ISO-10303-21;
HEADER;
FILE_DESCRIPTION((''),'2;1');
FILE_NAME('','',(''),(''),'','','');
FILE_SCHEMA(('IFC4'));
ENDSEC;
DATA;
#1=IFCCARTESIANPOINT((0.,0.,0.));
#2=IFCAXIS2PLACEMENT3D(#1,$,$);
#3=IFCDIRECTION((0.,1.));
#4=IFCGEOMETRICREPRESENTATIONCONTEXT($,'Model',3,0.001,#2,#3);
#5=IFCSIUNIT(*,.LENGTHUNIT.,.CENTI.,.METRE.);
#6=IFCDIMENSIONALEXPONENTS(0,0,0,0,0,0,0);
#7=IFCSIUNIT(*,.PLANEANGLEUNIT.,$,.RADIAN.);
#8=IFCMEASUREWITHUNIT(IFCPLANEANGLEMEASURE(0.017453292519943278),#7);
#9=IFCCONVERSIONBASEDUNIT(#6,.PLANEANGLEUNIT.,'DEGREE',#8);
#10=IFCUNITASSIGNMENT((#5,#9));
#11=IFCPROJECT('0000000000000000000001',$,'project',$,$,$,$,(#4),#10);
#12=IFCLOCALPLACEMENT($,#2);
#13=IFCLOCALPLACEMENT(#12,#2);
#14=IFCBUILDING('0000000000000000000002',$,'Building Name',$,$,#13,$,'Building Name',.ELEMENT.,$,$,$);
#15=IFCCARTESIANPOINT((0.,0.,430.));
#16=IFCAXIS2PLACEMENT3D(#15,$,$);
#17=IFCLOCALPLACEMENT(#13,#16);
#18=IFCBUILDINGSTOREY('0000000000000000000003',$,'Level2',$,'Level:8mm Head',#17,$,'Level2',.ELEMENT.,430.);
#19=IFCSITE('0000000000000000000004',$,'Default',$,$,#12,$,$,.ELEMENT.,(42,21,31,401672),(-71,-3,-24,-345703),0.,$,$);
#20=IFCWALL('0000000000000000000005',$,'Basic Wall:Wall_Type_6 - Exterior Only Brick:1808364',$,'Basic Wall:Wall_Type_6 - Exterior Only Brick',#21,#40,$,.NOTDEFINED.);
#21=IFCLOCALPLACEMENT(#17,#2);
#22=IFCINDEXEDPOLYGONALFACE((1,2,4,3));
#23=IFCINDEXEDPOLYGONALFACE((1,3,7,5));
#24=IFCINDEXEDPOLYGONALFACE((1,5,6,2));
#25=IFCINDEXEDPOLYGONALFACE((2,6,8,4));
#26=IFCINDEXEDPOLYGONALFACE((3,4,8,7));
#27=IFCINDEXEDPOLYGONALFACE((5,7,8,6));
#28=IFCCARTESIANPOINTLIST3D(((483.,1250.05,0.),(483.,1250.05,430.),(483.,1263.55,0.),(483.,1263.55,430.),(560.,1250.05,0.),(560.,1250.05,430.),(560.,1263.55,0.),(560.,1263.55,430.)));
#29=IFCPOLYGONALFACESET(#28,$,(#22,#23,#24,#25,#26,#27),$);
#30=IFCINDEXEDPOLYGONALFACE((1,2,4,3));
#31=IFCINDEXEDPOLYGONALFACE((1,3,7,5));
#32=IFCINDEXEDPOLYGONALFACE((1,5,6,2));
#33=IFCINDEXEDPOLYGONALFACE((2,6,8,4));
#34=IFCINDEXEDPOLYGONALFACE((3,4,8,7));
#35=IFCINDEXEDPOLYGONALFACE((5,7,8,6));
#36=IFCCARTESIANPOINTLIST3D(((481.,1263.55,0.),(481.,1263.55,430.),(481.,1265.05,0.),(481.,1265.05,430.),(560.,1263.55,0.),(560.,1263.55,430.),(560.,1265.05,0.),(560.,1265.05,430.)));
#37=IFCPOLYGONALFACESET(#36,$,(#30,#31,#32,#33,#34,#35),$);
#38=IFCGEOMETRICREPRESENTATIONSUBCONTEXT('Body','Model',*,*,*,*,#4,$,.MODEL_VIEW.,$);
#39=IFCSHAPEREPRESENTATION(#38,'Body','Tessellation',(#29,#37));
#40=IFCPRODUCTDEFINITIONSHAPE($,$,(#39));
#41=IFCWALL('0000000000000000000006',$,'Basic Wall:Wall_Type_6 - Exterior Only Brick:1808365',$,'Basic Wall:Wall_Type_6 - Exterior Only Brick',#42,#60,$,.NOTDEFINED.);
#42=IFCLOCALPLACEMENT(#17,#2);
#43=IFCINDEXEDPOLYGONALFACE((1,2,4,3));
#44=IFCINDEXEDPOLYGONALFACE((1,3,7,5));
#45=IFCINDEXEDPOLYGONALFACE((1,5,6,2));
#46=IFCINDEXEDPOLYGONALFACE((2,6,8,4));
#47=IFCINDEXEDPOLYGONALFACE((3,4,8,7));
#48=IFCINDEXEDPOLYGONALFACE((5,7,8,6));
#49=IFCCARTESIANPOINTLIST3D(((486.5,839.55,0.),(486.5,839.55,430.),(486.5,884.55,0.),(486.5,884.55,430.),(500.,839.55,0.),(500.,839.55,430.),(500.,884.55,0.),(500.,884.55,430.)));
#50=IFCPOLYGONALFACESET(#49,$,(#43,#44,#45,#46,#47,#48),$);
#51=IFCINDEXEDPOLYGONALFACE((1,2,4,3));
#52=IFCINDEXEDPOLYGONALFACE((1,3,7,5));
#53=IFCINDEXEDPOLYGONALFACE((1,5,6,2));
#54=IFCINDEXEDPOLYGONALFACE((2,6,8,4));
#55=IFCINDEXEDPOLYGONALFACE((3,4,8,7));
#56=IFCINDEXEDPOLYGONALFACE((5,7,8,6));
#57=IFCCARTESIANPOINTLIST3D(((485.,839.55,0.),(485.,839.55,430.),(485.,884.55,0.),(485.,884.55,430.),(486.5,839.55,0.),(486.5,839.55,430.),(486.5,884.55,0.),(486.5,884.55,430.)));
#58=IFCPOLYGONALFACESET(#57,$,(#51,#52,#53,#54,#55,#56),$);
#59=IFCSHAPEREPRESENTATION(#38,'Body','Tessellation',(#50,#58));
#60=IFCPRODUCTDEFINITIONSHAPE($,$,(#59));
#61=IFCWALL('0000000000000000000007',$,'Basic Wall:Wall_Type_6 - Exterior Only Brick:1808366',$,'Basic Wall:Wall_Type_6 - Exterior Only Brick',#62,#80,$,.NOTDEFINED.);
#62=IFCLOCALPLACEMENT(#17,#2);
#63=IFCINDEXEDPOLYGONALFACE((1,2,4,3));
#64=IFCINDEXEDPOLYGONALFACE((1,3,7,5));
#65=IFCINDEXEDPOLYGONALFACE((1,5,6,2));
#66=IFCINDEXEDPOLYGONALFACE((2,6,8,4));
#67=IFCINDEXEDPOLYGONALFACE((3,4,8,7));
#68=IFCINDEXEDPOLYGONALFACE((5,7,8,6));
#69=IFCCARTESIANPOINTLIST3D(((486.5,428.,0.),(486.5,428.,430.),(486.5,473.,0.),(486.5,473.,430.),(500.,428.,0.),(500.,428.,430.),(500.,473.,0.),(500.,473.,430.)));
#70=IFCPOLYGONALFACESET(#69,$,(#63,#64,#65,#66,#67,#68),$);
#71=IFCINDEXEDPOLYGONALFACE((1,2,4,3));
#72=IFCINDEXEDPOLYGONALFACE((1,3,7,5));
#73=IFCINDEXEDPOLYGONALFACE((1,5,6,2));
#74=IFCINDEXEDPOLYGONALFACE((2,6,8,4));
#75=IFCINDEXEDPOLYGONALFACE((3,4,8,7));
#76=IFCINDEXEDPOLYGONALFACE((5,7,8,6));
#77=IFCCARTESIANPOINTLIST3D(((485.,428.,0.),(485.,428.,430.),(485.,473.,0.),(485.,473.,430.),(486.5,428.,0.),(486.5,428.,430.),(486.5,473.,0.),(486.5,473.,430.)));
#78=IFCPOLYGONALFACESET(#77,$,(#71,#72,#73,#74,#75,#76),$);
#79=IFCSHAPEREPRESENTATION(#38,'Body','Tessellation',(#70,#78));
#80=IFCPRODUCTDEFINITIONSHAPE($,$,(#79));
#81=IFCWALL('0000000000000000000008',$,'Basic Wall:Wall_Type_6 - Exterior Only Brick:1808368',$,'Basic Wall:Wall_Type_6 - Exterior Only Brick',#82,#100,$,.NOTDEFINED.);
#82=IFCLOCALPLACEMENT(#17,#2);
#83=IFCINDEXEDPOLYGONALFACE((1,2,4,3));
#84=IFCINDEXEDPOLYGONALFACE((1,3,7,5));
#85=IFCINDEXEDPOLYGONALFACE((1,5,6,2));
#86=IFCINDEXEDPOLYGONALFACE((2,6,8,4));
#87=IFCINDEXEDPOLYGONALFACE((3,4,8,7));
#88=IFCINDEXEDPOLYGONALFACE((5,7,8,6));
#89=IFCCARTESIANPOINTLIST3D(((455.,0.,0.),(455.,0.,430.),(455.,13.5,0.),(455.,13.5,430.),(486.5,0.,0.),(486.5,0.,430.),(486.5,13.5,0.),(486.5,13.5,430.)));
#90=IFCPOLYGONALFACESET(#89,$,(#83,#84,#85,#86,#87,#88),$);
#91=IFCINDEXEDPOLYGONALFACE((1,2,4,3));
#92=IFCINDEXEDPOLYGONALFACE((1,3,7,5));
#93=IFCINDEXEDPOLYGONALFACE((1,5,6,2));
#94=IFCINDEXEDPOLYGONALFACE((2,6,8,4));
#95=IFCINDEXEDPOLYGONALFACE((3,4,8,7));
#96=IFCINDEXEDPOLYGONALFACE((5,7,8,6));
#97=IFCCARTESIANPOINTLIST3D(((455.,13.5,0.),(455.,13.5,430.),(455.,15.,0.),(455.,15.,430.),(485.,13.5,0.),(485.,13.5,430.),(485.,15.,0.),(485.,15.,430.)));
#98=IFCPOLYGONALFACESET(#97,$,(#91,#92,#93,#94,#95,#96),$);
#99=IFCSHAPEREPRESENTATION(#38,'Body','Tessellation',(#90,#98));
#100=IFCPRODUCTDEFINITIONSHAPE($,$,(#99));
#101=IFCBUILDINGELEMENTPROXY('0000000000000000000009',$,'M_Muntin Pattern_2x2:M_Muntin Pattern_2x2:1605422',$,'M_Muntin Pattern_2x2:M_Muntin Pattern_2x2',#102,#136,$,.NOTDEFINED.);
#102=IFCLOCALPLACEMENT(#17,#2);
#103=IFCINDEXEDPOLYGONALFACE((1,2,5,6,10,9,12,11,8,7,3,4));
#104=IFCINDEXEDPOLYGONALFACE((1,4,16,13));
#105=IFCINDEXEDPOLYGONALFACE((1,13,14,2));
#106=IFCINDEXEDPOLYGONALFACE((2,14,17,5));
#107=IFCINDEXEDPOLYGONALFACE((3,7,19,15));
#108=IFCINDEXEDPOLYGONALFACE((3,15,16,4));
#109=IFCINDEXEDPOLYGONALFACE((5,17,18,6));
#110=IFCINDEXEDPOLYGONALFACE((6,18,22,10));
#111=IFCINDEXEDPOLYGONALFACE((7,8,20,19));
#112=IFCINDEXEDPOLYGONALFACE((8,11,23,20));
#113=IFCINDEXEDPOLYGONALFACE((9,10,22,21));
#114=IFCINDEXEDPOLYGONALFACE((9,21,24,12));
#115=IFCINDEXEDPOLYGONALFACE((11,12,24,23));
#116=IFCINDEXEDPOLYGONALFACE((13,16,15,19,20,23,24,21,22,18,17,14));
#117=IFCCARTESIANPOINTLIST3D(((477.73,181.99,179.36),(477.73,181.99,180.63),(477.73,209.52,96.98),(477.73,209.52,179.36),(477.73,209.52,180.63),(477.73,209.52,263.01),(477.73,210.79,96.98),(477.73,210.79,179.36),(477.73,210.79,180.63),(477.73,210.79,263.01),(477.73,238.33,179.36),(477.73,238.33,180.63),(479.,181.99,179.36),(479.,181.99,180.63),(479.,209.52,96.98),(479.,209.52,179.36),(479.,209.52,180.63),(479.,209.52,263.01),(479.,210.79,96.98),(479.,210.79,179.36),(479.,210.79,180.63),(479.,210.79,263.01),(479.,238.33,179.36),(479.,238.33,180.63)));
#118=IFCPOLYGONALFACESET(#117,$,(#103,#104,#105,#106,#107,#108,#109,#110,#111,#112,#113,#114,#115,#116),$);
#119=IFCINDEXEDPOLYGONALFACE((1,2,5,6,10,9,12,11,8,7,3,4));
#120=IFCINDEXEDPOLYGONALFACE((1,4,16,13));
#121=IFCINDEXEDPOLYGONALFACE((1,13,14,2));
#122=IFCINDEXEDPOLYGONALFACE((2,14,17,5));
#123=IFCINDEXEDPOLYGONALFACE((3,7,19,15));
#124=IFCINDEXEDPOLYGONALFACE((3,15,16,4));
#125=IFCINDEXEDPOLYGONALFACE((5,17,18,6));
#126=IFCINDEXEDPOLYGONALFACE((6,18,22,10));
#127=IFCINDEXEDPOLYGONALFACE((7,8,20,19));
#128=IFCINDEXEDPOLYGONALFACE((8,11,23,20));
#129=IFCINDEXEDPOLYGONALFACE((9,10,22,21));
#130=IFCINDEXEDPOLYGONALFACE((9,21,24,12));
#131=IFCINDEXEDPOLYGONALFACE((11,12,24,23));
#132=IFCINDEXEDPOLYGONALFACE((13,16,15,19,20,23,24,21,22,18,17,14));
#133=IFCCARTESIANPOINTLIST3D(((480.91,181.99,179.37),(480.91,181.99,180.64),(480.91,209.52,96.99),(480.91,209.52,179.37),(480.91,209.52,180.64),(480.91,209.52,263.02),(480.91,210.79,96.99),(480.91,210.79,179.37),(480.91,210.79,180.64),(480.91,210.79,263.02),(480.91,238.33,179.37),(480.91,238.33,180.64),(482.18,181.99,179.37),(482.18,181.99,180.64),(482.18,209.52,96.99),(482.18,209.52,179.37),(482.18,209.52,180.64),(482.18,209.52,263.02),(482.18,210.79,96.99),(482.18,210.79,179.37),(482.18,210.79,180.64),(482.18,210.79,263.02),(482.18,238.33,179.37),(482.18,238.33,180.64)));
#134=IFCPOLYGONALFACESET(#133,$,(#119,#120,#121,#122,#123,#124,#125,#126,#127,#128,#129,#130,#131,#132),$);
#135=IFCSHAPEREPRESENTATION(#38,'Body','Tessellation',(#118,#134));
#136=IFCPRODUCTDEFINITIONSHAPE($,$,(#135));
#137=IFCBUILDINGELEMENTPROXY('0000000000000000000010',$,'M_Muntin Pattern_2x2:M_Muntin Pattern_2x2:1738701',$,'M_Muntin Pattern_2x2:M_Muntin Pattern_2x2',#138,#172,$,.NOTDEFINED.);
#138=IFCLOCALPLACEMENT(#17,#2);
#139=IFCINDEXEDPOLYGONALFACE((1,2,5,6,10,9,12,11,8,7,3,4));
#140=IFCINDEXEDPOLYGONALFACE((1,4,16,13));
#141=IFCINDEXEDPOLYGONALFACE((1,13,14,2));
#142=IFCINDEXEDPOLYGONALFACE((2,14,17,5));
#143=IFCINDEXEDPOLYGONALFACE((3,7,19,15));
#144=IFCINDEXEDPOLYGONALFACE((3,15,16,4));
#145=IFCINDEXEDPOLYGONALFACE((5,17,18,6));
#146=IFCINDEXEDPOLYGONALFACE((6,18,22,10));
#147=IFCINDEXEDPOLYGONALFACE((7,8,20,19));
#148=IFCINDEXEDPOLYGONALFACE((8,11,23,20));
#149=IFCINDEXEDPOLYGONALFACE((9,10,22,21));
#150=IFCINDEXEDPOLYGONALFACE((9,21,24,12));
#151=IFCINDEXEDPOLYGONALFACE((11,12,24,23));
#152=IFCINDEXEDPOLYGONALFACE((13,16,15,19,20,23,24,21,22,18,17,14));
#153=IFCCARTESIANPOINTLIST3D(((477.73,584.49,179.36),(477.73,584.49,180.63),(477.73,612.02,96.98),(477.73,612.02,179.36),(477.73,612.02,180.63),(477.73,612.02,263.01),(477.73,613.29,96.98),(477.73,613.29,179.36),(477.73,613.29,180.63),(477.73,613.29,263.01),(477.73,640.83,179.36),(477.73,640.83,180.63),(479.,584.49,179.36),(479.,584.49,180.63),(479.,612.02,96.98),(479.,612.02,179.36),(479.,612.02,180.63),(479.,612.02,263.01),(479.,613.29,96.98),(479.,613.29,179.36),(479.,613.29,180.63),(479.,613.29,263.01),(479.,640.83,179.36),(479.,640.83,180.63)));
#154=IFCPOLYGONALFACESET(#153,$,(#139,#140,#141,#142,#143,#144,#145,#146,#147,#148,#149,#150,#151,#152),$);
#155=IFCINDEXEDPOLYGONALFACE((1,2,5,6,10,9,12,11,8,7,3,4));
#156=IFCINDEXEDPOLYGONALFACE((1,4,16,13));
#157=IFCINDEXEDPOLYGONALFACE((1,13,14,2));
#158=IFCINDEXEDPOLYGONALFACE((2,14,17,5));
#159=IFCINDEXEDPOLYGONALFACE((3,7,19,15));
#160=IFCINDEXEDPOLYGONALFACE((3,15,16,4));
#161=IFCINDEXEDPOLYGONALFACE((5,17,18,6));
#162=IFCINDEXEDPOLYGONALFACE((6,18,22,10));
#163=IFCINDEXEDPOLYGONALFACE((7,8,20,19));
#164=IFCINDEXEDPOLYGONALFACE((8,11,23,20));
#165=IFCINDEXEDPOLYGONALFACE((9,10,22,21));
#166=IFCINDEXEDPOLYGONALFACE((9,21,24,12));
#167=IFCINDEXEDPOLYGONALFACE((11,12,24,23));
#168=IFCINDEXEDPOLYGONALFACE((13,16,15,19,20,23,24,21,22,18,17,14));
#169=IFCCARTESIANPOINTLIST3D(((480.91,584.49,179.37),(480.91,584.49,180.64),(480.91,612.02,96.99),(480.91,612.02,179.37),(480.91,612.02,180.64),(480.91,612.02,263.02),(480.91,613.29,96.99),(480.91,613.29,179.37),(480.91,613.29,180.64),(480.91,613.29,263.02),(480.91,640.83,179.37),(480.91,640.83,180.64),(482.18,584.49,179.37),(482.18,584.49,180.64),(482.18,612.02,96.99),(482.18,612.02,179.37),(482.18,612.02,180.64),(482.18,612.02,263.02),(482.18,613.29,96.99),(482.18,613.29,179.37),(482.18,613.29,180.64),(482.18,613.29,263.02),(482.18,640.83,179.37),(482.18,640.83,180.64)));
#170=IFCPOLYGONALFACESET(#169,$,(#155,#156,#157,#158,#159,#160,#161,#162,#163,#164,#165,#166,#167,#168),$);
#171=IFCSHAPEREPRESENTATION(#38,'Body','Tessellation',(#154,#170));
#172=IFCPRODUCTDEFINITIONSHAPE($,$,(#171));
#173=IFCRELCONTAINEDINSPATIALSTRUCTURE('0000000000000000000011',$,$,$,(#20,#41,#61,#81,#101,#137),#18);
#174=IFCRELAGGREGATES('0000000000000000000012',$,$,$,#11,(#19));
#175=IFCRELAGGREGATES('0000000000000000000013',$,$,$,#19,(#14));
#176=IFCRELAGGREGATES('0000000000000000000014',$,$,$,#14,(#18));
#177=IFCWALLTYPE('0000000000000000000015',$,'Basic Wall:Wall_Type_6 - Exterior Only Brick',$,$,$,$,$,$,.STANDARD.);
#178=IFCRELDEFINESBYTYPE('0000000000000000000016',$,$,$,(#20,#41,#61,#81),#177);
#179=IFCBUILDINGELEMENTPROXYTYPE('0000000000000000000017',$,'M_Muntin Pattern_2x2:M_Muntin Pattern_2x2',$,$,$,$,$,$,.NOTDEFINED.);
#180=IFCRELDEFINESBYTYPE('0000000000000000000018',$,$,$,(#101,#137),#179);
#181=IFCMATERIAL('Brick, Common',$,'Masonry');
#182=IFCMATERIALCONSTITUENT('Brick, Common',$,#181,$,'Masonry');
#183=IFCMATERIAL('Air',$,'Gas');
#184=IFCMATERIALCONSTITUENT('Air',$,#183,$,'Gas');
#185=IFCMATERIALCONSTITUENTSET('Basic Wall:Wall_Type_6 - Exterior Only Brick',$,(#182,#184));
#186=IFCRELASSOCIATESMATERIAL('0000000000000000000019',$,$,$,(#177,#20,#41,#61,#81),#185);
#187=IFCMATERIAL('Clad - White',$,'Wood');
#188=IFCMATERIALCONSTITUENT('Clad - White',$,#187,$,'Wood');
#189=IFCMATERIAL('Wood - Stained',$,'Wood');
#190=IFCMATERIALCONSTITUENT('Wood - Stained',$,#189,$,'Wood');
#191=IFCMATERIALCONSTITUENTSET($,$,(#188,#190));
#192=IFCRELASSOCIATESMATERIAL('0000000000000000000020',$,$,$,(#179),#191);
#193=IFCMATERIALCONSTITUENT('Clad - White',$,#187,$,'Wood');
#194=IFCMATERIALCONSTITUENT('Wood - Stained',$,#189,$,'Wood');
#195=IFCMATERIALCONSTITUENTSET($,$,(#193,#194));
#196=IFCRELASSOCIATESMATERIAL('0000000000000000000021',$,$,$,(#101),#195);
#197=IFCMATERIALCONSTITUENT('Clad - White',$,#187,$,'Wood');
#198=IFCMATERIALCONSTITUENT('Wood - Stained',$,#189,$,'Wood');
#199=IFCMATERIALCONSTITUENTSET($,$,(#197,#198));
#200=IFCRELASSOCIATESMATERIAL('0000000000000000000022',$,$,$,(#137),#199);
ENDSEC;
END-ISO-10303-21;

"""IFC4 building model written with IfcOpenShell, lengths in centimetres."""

from ifc_helpers import new_model, entity, si_unit, converted_unit, direction, frame, origin, place, context, subcontext, project, spatial, indexed_curve, outline, extrude, source, transform, mapped, material, constituent, constituent_set, type_object, type_shapes, element, save


model = new_model("IFC4")

# Units and contexts
model_context = context("Model", 3, precision=0.001, world=origin(), true_north=direction((0.0, 1.0)))
body_context = subcontext(model_context, "Body", "Model", "MODEL_VIEW")
ifc_project = project(units=[si_unit("LENGTHUNIT", "METRE", prefix="CENTI"), converted_unit("PLANEANGLEUNIT", "DEGREE", entity("IfcPlaneAngleMeasure", 0.017453292519943278), si_unit("PLANEANGLEUNIT", "RADIAN"), dimensions=[0, 0, 0, 0, 0, 0, 0])], contexts=[model_context])

# Site, building, storey
site_placement = place(None, origin())
site = spatial("IfcSite", under=ifc_project, at=site_placement, Name="Default", CompositionType="ELEMENT", RefLatitude=(42, 21, 31, 401672), RefLongitude=(-71, -3, -24, -345703), RefElevation=0.0)
building_placement = place(site_placement, origin())
building = spatial("IfcBuilding", under=site, at=building_placement, Name="Building Name", LongName="Building Name", CompositionType="ELEMENT")
storey_placement = place(building_placement, frame((0.0, 0.0, 430.0)))
storey = spatial("IfcBuildingStorey", under=building, at=storey_placement, Name="Level2", ObjectType="Level:8mm Head", LongName="Level2", CompositionType="ELEMENT", Elevation=430.0)

# Shared definitions
ifc_material_1 = material(Name="Brick, Common", Category="Masonry")
ifc_material_2 = material(Name="Air", Category="Gas")

# Walls
ifc_constituent_1 = constituent(ifc_material_1, Name="Brick, Common", Category="Masonry")
ifc_constituent_2 = constituent(ifc_material_2, Name="Air", Category="Gas")
ifc_constituent_set_1 = constituent_set(constituents=[ifc_constituent_1, ifc_constituent_2], Name="Basic Wall:Wall_Type_6 - Exterior Only Brick")
wall_type_1 = type_object("IfcWallType", Name="Basic Wall:Wall_Type_6 - Exterior Only Brick", PredefinedType="STANDARD", material=ifc_constituent_set_1)
wall_1_placement = place(storey_placement, frame((560.0, 1257.55, 0.0), z_axis=(0.0, 0.0, 1.0), x_axis=(-1.0, 0.0, 0.0)))
element("IfcWall", 1, at=wall_1_placement, inside=storey, type_object=wall_type_1, material=ifc_constituent_set_1, Name="Basic Wall:Wall_Type_6 - Exterior Only Brick:1808364", ObjectType="Basic Wall:Wall_Type_6 - Exterior Only Brick", PredefinedType="NOTDEFINED", context=body_context, shape_type="SweptSolid", body=[
    extrude(outline(indexed_curve([(-6.75, -38.5), (6.75, -38.5), (6.75, 38.5), (-6.75, 38.5), (-6.75, -38.5)], self_intersect=False)), frame((38.5, 0.75, 0.0), z_axis=(0.0, 0.0, 1.0), x_axis=(0.0, -1.0, 0.0)), (0.0, 0.0, 1.0), 430.0),
    extrude(outline(indexed_curve([(-0.75, -39.5), (0.75, -39.5), (0.75, 39.5), (-0.75, 39.5), (-0.75, -39.5)], self_intersect=False)), frame((39.5, -6.75, 0.0), z_axis=(0.0, 0.0, 1.0), x_axis=(0.0, -1.0, 0.0)), (0.0, 0.0, 1.0), 430.0),
])
wall_2_placement = place(storey_placement, frame((492.5, 884.55, 0.0), z_axis=(0.0, 0.0, 1.0), x_axis=(0.0, -1.0, 0.0)))
element("IfcWall", 2, at=wall_2_placement, inside=storey, type_object=wall_type_1, material=ifc_constituent_set_1, Name="Basic Wall:Wall_Type_6 - Exterior Only Brick:1808365", ObjectType="Basic Wall:Wall_Type_6 - Exterior Only Brick", PredefinedType="NOTDEFINED", context=body_context, shape_type="SweptSolid", body=[
    extrude(outline(indexed_curve([(-6.75, -22.5), (6.75, -22.5), (6.75, 22.5), (-6.75, 22.5), (-6.75, -22.5)], self_intersect=False)), frame((22.5, 0.75, 0.0), z_axis=(0.0, 0.0, 1.0), x_axis=(0.0, -1.0, 0.0)), (0.0, 0.0, 1.0), 430.0),
    extrude(outline(indexed_curve([(-0.75, -22.5), (0.75, -22.5), (0.75, 22.5), (-0.75, 22.5), (-0.75, -22.5)], self_intersect=False)), frame((22.5, -6.75, 0.0), z_axis=(0.0, 0.0, 1.0), x_axis=(0.0, 1.0, 0.0)), (0.0, 0.0, 1.0), 430.0),
])
wall_3_placement = place(storey_placement, frame((492.5, 473.0, 0.0), z_axis=(0.0, 0.0, 1.0), x_axis=(0.0, -1.0, 0.0)))
element("IfcWall", 3, at=wall_3_placement, inside=storey, type_object=wall_type_1, material=ifc_constituent_set_1, Name="Basic Wall:Wall_Type_6 - Exterior Only Brick:1808366", ObjectType="Basic Wall:Wall_Type_6 - Exterior Only Brick", PredefinedType="NOTDEFINED", context=body_context, shape_type="SweptSolid", body=[
    extrude(outline(indexed_curve([(-6.75, -22.5), (6.75, -22.5), (6.75, 22.5), (-6.75, 22.5), (-6.75, -22.5)], self_intersect=False)), frame((22.5, 0.75, 0.0), z_axis=(0.0, 0.0, 1.0), x_axis=(0.0, -1.0, 0.0)), (0.0, 0.0, 1.0), 430.0),
    extrude(outline(indexed_curve([(-0.75, -22.5), (0.75, -22.5), (0.75, 22.5), (-0.75, 22.5), (-0.75, -22.5)], self_intersect=False)), frame((22.5, -6.75, 0.0), z_axis=(0.0, 0.0, 1.0), x_axis=(0.0, 1.0, 0.0)), (0.0, 0.0, 1.0), 430.0),
])
wall_4_placement = place(storey_placement, frame((485.0, 7.5, 0.0), z_axis=(0.0, 0.0, 1.0), x_axis=(-1.0, 0.0, 0.0)))
element("IfcWall", 4, at=wall_4_placement, inside=storey, type_object=wall_type_1, material=ifc_constituent_set_1, Name="Basic Wall:Wall_Type_6 - Exterior Only Brick:1808368", ObjectType="Basic Wall:Wall_Type_6 - Exterior Only Brick", PredefinedType="NOTDEFINED", context=body_context, shape_type="SweptSolid", body=[
    extrude(outline(indexed_curve([(-6.75, -15.75), (6.75, -15.75), (6.75, 15.75), (-6.75, 15.75), (-6.75, -15.75)], self_intersect=False)), frame((14.25, 0.75, 0.0), z_axis=(0.0, 0.0, 1.0), x_axis=(0.0, -1.0, 0.0)), (0.0, 0.0, 1.0), 430.0),
    extrude(outline(indexed_curve([(-0.75, -15.0), (0.75, -15.0), (0.75, 15.0), (-0.75, 15.0), (-0.75, -15.0)], self_intersect=False)), frame((15.0, -6.75, 0.0), z_axis=(0.0, 0.0, 1.0), x_axis=(0.0, 1.0, 0.0)), (0.0, 0.0, 1.0), 430.0),
])

# Building element proxies
ifc_material_3 = material(Name="Clad - White", Category="Wood")
ifc_constituent_3 = constituent(ifc_material_3, Name="Clad - White", Category="Wood")
ifc_material_4 = material(Name="Wood - Stained", Category="Wood")
ifc_constituent_4 = constituent(ifc_material_4, Name="Wood - Stained", Category="Wood")
ifc_constituent_set_2 = constituent_set(constituents=[ifc_constituent_3, ifc_constituent_4])
ifc_constituent_5 = constituent(ifc_material_3, Name="Clad - White", Category="Wood")
ifc_constituent_6 = constituent(ifc_material_4, Name="Wood - Stained", Category="Wood")
ifc_constituent_set_3 = constituent_set(constituents=[ifc_constituent_5, ifc_constituent_6])
building_element_proxy_type_1 = type_object("IfcBuildingElementProxyType", Name="M_Muntin Pattern_2x2:M_Muntin Pattern_2x2", PredefinedType="NOTDEFINED", material=ifc_constituent_set_3)
shared_shape_1 = source(origin(), body_context, "Body", "SweptSolid", [
    extrude(outline(indexed_curve([(0.64, -0.64), (83.01, -0.64), (83.01, 0.63), (0.64, 0.63), (0.64, 28.17), (-0.63, 28.17), (-0.63, 0.63), (-83.02, 0.63), (-83.02, -0.64), (-0.63, -0.64), (-0.63, -28.17), (0.64, -28.17), (0.64, -0.64)], self_intersect=False)), frame((0.0, 0.95, 83.01), z_axis=(0.0, 1.0, 0.0), x_axis=(0.0, 0.0, 1.0)), (0.0, 0.0, 1.0), 1.27),
    extrude(outline(indexed_curve([(0.64, -0.64), (83.02, -0.64), (83.02, 0.63), (0.64, 0.63), (0.64, 28.17), (-0.63, 28.17), (-0.63, 0.63), (-83.02, 0.63), (-83.02, -0.64), (-0.63, -0.64), (-0.63, -28.17), (0.64, -28.17), (0.64, -0.64)], self_intersect=False)), frame((0.0, -2.22, 83.02), z_axis=(0.0, 1.0, 0.0), x_axis=(0.0, 0.0, 1.0)), (0.0, 0.0, 1.0), 1.27),
])
type_shapes(building_element_proxy_type_1, [shared_shape_1])
proxy_1_placement = place(storey_placement, frame((479.95, 210.16, 96.99), z_axis=(0.0, 0.0, 1.0), x_axis=(0.0, 1.0, 0.0)))
element("IfcBuildingElementProxy", 5, at=proxy_1_placement, inside=storey, type_object=building_element_proxy_type_1, material=ifc_constituent_set_2, Name="M_Muntin Pattern_2x2:M_Muntin Pattern_2x2:1605422", ObjectType="M_Muntin Pattern_2x2:M_Muntin Pattern_2x2", PredefinedType="NOTDEFINED", context=body_context, shape_type="MappedRepresentation", body=[
    mapped(shared_shape_1, transform((0.0, 0.0, 0.0), scale=1.0)),
])
ifc_constituent_7 = constituent(ifc_material_3, Name="Clad - White", Category="Wood")
ifc_constituent_8 = constituent(ifc_material_4, Name="Wood - Stained", Category="Wood")
ifc_constituent_set_4 = constituent_set(constituents=[ifc_constituent_7, ifc_constituent_8])
proxy_2_placement = place(storey_placement, frame((479.95, 612.66, 96.99), z_axis=(0.0, 0.0, 1.0), x_axis=(0.0, 1.0, 0.0)))
element("IfcBuildingElementProxy", 6, at=proxy_2_placement, inside=storey, type_object=building_element_proxy_type_1, material=ifc_constituent_set_4, Name="M_Muntin Pattern_2x2:M_Muntin Pattern_2x2:1738701", ObjectType="M_Muntin Pattern_2x2:M_Muntin Pattern_2x2", PredefinedType="NOTDEFINED", context=body_context, shape_type="MappedRepresentation", body=[
    mapped(shared_shape_1, transform((0.0, 0.0, 0.0), scale=1.0)),
])

save(model, "model.ifc")
